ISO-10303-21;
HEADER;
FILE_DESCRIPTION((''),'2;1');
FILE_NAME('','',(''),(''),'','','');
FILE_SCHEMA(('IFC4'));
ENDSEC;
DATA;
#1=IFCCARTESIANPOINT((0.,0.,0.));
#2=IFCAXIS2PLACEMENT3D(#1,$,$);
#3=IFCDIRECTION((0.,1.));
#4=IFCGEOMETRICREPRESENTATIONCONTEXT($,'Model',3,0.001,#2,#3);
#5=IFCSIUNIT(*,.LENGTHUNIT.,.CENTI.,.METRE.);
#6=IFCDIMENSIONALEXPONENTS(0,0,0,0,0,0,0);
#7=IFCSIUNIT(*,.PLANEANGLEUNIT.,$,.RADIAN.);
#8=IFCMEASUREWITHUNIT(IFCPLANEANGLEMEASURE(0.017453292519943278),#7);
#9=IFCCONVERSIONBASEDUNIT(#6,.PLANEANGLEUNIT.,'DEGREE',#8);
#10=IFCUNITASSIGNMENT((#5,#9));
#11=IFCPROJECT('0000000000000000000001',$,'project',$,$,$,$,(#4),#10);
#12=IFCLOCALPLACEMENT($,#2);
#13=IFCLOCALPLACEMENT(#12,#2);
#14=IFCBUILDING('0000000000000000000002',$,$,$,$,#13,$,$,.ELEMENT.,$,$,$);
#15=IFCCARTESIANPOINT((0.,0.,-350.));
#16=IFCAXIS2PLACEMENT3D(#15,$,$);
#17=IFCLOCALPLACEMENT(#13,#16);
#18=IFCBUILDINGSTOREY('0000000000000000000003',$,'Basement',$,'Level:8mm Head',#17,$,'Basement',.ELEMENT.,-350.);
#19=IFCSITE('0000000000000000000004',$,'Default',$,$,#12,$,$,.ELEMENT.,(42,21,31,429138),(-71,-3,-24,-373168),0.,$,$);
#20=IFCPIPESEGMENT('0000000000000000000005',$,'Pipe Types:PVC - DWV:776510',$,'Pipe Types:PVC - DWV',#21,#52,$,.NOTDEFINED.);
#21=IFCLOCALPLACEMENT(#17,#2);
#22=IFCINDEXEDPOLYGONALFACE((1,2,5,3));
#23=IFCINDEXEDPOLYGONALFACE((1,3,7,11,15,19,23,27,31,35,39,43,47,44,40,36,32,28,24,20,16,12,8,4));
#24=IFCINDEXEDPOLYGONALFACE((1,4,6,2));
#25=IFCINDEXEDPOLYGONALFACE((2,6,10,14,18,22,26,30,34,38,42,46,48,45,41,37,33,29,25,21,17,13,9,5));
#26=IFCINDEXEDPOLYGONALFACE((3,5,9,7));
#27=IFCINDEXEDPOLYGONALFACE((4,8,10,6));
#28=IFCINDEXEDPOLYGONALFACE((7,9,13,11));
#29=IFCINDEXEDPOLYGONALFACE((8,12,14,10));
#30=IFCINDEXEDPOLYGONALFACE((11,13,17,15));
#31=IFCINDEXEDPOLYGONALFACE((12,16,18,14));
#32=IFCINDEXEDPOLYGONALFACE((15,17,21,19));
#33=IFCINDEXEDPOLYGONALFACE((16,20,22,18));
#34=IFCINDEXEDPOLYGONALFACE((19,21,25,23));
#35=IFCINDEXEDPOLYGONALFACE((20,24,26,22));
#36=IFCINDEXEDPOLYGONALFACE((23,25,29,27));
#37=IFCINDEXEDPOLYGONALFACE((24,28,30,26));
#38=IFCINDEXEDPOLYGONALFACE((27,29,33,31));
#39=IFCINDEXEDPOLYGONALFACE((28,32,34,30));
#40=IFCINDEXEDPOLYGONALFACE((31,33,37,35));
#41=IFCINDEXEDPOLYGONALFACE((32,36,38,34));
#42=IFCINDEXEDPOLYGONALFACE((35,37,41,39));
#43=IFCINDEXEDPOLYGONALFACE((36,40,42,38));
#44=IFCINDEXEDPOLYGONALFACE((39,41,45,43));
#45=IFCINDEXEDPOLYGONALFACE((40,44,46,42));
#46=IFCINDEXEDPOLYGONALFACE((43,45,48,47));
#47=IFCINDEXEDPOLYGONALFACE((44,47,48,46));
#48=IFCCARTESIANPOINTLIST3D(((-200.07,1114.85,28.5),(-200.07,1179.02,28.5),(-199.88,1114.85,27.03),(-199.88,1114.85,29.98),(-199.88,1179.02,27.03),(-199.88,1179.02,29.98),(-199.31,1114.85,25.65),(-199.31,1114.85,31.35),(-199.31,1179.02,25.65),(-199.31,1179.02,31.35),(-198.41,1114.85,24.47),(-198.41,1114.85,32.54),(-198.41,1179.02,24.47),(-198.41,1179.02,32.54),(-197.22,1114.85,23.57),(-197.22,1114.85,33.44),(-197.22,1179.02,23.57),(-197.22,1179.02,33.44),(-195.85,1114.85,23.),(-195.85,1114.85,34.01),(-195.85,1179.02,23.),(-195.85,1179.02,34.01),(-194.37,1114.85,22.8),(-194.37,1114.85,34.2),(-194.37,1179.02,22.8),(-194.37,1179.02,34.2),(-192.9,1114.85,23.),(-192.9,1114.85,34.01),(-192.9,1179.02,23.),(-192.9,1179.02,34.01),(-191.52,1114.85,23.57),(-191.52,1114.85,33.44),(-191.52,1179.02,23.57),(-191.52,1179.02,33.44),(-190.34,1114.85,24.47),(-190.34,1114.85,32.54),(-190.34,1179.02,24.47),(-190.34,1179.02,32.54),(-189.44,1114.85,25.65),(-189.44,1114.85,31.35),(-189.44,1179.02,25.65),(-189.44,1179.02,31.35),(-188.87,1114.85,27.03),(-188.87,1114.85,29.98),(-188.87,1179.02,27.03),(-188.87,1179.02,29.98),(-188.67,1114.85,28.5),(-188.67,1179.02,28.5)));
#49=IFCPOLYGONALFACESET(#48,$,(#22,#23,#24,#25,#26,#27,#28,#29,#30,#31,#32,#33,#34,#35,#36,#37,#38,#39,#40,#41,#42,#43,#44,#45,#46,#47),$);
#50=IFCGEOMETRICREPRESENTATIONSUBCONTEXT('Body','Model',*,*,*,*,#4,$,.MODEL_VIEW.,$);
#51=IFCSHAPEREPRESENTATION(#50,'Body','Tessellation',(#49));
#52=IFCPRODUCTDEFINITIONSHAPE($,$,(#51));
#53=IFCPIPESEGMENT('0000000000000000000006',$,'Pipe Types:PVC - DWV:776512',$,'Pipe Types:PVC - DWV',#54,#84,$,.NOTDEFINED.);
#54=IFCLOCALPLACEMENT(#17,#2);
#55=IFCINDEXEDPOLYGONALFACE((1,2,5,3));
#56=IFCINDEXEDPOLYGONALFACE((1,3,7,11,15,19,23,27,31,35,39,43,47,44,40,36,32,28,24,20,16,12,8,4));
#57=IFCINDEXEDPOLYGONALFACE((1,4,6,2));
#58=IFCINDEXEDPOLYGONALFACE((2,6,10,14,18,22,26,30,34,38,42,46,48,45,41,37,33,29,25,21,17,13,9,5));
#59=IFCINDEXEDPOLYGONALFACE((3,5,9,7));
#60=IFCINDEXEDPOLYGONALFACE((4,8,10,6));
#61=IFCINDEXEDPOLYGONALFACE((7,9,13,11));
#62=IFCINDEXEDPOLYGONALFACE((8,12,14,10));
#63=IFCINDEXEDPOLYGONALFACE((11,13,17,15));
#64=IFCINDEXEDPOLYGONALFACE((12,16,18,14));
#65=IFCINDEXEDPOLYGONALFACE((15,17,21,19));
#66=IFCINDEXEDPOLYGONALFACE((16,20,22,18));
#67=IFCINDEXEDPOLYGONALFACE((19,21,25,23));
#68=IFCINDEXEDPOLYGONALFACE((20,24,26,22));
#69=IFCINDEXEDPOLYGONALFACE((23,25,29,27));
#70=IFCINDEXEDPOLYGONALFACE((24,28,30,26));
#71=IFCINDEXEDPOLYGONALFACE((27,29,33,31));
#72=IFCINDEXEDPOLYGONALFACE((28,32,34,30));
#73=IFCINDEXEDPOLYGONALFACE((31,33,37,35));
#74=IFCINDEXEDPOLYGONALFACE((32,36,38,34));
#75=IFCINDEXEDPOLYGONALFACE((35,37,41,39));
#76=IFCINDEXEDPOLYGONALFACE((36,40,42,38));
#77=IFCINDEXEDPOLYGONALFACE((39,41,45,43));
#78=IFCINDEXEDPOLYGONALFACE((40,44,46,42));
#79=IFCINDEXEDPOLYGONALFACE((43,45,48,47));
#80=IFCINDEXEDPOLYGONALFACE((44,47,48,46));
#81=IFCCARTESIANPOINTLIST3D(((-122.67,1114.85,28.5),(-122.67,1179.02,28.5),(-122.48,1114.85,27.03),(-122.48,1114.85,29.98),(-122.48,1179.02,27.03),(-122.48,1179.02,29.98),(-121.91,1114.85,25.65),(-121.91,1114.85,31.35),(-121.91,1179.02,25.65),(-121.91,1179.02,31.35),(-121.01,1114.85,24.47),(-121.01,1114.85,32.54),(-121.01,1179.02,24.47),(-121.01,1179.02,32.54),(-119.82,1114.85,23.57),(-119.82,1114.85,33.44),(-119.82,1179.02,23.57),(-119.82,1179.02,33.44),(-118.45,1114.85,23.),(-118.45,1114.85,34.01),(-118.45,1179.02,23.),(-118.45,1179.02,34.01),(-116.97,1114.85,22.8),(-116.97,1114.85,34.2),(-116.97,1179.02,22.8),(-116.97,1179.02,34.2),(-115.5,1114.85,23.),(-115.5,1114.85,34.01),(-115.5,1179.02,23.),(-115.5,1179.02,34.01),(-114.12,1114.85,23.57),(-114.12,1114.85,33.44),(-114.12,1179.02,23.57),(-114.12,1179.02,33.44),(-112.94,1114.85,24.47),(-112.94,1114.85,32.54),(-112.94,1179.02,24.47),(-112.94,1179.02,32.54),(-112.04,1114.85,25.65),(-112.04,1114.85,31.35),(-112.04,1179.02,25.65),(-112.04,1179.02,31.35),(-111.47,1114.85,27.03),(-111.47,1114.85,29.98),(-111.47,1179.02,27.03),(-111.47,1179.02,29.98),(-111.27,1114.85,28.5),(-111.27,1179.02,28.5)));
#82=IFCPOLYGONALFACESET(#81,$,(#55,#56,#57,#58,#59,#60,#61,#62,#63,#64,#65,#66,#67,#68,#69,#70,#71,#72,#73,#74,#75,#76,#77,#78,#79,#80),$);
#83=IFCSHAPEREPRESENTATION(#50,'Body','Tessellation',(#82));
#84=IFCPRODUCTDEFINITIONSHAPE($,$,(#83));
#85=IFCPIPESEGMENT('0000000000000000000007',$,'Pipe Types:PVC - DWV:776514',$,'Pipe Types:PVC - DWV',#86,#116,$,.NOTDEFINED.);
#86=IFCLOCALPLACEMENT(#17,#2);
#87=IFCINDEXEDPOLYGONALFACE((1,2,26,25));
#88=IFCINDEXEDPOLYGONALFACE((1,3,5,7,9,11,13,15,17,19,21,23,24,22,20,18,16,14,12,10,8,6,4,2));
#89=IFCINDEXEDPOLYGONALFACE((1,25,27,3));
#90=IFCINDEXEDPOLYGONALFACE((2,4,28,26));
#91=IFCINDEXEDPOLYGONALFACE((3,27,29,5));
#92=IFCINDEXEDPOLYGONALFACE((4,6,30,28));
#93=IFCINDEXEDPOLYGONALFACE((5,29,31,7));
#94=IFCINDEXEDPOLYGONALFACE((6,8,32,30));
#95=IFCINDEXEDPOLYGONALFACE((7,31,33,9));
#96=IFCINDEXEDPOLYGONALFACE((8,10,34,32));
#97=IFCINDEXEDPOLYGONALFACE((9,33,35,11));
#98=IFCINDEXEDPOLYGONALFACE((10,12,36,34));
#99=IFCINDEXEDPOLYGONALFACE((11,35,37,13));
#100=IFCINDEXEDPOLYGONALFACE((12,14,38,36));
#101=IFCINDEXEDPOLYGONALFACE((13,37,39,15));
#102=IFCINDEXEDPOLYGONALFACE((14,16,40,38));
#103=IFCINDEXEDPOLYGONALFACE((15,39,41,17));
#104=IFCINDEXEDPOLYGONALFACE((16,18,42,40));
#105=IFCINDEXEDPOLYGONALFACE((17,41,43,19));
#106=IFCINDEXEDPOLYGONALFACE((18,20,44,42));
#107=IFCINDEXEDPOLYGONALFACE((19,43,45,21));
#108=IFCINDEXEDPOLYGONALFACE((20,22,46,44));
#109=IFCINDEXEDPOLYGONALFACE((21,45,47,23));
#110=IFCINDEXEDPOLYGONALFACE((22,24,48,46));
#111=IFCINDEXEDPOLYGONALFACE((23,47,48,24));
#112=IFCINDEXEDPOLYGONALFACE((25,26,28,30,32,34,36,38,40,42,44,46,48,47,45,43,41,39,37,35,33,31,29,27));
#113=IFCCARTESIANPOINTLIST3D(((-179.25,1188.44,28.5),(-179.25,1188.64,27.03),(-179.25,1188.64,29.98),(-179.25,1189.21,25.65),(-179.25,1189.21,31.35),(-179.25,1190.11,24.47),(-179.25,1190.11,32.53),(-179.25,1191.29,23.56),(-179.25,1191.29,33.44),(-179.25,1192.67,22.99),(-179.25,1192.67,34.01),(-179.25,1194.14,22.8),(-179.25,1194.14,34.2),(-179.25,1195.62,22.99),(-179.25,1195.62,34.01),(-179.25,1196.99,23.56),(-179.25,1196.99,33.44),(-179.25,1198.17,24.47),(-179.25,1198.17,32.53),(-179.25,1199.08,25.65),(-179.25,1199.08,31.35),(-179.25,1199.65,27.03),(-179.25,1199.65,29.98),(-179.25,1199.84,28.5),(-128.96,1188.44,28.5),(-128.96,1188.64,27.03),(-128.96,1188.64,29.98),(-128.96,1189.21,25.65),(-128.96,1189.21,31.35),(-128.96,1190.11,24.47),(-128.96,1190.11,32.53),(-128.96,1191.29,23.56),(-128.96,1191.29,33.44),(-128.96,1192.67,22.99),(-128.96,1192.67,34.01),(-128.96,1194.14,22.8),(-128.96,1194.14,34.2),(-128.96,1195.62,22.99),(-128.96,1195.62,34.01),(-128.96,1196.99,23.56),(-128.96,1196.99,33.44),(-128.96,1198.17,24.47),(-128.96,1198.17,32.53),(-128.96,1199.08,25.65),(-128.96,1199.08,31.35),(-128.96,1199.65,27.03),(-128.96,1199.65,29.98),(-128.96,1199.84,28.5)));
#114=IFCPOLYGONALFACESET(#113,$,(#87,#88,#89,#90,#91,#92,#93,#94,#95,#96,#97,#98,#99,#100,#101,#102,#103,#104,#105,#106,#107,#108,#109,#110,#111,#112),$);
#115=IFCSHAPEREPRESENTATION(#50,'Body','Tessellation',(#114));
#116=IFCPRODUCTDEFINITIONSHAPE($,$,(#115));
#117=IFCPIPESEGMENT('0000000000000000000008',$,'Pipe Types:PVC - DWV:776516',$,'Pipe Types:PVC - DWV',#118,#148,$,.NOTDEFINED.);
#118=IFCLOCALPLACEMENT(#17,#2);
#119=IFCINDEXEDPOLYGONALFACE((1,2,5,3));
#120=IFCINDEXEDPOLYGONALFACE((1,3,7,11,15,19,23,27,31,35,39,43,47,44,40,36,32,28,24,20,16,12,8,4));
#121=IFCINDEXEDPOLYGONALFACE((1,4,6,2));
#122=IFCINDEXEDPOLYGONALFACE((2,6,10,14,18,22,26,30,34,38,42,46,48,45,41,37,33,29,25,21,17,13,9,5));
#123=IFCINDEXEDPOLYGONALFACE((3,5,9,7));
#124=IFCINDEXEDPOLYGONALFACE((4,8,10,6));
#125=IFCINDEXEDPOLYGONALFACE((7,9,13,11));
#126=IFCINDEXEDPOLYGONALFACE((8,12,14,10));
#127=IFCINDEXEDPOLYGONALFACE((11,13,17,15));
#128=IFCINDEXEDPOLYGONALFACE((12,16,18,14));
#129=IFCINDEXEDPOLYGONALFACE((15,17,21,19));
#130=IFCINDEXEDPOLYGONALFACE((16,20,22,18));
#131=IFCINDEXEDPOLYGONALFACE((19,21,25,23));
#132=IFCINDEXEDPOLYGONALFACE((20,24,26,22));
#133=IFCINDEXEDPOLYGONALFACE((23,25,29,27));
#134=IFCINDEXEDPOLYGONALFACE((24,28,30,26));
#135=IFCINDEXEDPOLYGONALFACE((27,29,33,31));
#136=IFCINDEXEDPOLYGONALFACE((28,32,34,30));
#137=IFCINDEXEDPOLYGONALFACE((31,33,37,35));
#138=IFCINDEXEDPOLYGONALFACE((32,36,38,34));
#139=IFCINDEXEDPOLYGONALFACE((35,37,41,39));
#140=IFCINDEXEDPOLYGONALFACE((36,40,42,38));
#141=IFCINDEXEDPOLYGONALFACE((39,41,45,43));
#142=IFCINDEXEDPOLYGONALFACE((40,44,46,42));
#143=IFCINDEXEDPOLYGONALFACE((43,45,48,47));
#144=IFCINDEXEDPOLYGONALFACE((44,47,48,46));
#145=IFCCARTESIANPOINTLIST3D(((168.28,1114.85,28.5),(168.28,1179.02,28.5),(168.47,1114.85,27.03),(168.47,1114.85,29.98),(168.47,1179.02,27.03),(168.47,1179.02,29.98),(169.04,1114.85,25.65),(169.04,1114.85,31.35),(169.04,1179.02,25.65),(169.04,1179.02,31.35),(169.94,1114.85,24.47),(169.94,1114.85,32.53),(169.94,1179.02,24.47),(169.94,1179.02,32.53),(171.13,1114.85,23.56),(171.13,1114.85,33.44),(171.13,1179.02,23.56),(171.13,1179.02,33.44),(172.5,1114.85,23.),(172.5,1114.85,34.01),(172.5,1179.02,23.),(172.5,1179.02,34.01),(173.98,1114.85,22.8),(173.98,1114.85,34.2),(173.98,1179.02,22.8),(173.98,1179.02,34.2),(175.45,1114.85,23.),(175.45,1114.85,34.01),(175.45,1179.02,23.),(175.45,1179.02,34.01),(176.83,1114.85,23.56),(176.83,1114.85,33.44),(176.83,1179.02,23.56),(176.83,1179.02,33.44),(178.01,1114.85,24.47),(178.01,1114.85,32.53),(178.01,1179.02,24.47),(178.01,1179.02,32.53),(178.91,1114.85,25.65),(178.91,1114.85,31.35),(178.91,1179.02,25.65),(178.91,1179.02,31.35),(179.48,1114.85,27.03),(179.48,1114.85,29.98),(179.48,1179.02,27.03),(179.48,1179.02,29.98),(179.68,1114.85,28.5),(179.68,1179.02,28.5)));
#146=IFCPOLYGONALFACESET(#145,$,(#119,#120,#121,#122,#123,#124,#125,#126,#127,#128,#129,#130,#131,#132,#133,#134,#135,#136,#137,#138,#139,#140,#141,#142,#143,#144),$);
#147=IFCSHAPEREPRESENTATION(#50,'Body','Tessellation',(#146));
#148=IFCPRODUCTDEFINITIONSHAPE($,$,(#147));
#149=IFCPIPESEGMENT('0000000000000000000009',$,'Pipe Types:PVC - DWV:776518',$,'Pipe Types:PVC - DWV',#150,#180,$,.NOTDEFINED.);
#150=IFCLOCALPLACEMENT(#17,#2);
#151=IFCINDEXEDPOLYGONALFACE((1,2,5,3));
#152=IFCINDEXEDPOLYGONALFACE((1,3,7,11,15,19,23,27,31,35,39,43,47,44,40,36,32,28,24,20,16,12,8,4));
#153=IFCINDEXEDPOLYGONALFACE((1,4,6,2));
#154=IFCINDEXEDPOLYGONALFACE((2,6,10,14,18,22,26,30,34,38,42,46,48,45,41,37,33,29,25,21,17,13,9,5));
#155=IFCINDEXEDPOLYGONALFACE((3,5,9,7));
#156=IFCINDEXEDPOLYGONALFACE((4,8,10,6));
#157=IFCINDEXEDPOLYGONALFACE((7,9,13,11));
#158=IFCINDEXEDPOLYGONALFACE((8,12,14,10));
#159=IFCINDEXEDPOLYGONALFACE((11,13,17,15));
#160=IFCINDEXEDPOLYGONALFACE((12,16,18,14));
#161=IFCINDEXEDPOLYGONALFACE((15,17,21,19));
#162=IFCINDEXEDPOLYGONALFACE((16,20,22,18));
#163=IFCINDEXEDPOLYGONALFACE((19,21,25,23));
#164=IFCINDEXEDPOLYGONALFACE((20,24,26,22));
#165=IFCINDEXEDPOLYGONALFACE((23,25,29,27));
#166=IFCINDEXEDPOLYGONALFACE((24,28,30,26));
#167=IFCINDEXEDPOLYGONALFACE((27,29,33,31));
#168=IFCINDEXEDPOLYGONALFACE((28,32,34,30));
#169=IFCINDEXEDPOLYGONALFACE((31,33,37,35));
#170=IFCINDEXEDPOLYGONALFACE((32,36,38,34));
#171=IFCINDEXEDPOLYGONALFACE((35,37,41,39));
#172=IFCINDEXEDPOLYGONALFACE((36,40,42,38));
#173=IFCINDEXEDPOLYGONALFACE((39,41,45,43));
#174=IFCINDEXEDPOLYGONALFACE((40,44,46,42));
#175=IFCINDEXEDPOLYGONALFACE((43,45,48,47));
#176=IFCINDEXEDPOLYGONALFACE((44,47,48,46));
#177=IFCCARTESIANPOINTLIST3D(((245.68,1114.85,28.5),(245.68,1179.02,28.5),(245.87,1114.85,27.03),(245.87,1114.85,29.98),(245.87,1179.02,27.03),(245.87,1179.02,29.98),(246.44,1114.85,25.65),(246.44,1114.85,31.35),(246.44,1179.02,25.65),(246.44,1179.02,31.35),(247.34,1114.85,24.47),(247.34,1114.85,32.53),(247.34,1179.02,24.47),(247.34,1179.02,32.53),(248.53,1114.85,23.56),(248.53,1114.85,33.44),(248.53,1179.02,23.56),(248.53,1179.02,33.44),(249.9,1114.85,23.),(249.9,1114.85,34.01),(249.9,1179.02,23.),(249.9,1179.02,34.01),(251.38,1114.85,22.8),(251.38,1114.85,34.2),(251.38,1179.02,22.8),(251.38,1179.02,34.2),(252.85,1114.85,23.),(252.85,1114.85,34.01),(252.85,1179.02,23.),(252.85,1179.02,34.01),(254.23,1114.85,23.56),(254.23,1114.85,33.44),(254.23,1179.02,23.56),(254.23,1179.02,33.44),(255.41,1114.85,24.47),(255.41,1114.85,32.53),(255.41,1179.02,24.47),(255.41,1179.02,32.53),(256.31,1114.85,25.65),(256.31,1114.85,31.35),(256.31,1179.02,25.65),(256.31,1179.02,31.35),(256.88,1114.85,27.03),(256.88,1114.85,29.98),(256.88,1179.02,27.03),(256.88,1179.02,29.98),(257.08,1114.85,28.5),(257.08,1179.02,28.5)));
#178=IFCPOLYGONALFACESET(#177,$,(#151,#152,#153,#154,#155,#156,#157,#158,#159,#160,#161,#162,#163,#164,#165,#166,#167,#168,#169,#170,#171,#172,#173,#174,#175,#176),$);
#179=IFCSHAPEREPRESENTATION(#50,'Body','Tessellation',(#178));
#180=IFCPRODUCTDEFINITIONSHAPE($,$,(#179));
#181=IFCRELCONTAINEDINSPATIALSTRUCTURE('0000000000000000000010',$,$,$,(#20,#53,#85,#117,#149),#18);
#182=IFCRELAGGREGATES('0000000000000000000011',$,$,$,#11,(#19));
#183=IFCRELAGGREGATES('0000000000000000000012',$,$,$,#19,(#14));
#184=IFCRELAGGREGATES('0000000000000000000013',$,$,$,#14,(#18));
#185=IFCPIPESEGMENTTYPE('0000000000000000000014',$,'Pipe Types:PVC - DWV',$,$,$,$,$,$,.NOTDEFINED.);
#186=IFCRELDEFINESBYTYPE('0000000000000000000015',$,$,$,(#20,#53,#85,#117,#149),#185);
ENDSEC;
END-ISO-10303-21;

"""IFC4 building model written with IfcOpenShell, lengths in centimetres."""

from ifc_helpers import new_model, entity, si_unit, converted_unit, direction, frame, origin, place, context, subcontext, project, spatial, arc, indexed_curve, outline, extrude, type_object, element, save


model = new_model("IFC4")

# Units and contexts
model_context = context("Model", 3, precision=0.001, world=origin(), true_north=direction((0.0, 1.0)))
body_context = subcontext(model_context, "Body", "Model", "MODEL_VIEW")
ifc_project = project(units=[si_unit("LENGTHUNIT", "METRE", prefix="CENTI"), converted_unit("PLANEANGLEUNIT", "DEGREE", entity("IfcPlaneAngleMeasure", 0.017453292519943278), si_unit("PLANEANGLEUNIT", "RADIAN"), dimensions=[0, 0, 0, 0, 0, 0, 0])], contexts=[model_context])

# Site, building, storey
site_placement = place(None, origin())
site = spatial("IfcSite", under=ifc_project, at=site_placement, Name="Default", CompositionType="ELEMENT", RefLatitude=(42, 21, 31, 429138), RefLongitude=(-71, -3, -24, -373168), RefElevation=0.0)
building_placement = place(site_placement, origin())
building = spatial("IfcBuilding", under=site, at=building_placement, CompositionType="ELEMENT")
storey_placement = place(building_placement, frame((0.0, 0.0, -350.0)))
storey = spatial("IfcBuildingStorey", under=building, at=storey_placement, Name="Basement", ObjectType="Level:8mm Head", LongName="Basement", CompositionType="ELEMENT", Elevation=-350.0)

# Pipe segments
pipe_segment_type = type_object("IfcPipeSegmentType", Name="Pipe Types:PVC - DWV", PredefinedType="NOTDEFINED")
pipe_segment_1_placement = place(storey_placement, origin())
element("IfcPipeSegment", 1, at=pipe_segment_1_placement, inside=storey, type_object=pipe_segment_type, Name="Pipe Types:PVC - DWV:776510", ObjectType="Pipe Types:PVC - DWV", PredefinedType="NOTDEFINED", context=body_context, shape_type="SweptSolid", body=[
    extrude(outline(indexed_curve([(5.7, 0.0), (4.03, 4.03), (0.0, 5.7), (-4.03, 4.03), (-5.7, 0.0), (-4.03, -4.03), (0.0, -5.7), (4.03, -4.03)], segments=[arc(1, 2, 3), arc(3, 4, 5), arc(5, 6, 7), arc(7, 8, 1)], self_intersect=False)), frame((-194.37, 1114.85, 28.5), z_axis=(0.0, 1.0, 0.0), x_axis=(-1.0, 0.0, 0.0)), (0.0, 0.0, 1.0), 64.18),
])
pipe_segment_2_placement = place(storey_placement, origin())
element("IfcPipeSegment", 2, at=pipe_segment_2_placement, inside=storey, type_object=pipe_segment_type, Name="Pipe Types:PVC - DWV:776512", ObjectType="Pipe Types:PVC - DWV", PredefinedType="NOTDEFINED", context=body_context, shape_type="SweptSolid", body=[
    extrude(outline(indexed_curve([(5.7, 0.0), (4.03, 4.03), (0.0, 5.7), (-4.03, 4.03), (-5.7, 0.0), (-4.03, -4.03), (0.0, -5.7), (4.03, -4.03)], segments=[arc(1, 2, 3), arc(3, 4, 5), arc(5, 6, 7), arc(7, 8, 1)], self_intersect=False)), frame((-116.97, 1114.85, 28.5), z_axis=(0.0, 1.0, 0.0), x_axis=(-1.0, 0.0, 0.0)), (0.0, 0.0, 1.0), 64.18),
])
pipe_segment_3_placement = place(storey_placement, origin())
element("IfcPipeSegment", 3, at=pipe_segment_3_placement, inside=storey, type_object=pipe_segment_type, Name="Pipe Types:PVC - DWV:776514", ObjectType="Pipe Types:PVC - DWV", PredefinedType="NOTDEFINED", context=body_context, shape_type="SweptSolid", body=[
    extrude(outline(indexed_curve([(5.7, 0.0), (4.03, 4.03), (0.0, 5.7), (-4.03, 4.03), (-5.7, 0.0), (-4.03, -4.03), (0.0, -5.7), (4.03, -4.03)], segments=[arc(1, 2, 3), arc(3, 4, 5), arc(5, 6, 7), arc(7, 8, 1)], self_intersect=False)), frame((-179.25, 1194.14, 28.5), z_axis=(1.0, 0.0, 0.0), x_axis=(0.0, 1.0, 0.0)), (0.0, 0.0, 1.0), 50.29),
])
pipe_segment_4_placement = place(storey_placement, origin())
element("IfcPipeSegment", 4, at=pipe_segment_4_placement, inside=storey, type_object=pipe_segment_type, Name="Pipe Types:PVC - DWV:776516", ObjectType="Pipe Types:PVC - DWV", PredefinedType="NOTDEFINED", context=body_context, shape_type="SweptSolid", body=[
    extrude(outline(indexed_curve([(5.7, 0.0), (4.03, 4.03), (0.0, 5.7), (-4.03, 4.03), (-5.7, 0.0), (-4.03, -4.03), (0.0, -5.7), (4.03, -4.03)], segments=[arc(1, 2, 3), arc(3, 4, 5), arc(5, 6, 7), arc(7, 8, 1)], self_intersect=False)), frame((173.98, 1114.85, 28.5), z_axis=(0.0, 1.0, 0.0), x_axis=(1.0, 0.0, 0.0)), (0.0, 0.0, 1.0), 64.18),
])
pipe_segment_5_placement = place(storey_placement, origin())
element("IfcPipeSegment", 5, at=pipe_segment_5_placement, inside=storey, type_object=pipe_segment_type, Name="Pipe Types:PVC - DWV:776518", ObjectType="Pipe Types:PVC - DWV", PredefinedType="NOTDEFINED", context=body_context, shape_type="SweptSolid", body=[
    extrude(outline(indexed_curve([(5.7, 0.0), (4.03, 4.03), (0.0, 5.7), (-4.03, 4.03), (-5.7, 0.0), (-4.03, -4.03), (0.0, -5.7), (4.03, -4.03)], segments=[arc(1, 2, 3), arc(3, 4, 5), arc(5, 6, 7), arc(7, 8, 1)], self_intersect=False)), frame((251.38, 1114.85, 28.5), z_axis=(0.0, 1.0, 0.0), x_axis=(1.0, 0.0, 0.0)), (0.0, 0.0, 1.0), 64.18),
])

save(model, "model.ifc")
